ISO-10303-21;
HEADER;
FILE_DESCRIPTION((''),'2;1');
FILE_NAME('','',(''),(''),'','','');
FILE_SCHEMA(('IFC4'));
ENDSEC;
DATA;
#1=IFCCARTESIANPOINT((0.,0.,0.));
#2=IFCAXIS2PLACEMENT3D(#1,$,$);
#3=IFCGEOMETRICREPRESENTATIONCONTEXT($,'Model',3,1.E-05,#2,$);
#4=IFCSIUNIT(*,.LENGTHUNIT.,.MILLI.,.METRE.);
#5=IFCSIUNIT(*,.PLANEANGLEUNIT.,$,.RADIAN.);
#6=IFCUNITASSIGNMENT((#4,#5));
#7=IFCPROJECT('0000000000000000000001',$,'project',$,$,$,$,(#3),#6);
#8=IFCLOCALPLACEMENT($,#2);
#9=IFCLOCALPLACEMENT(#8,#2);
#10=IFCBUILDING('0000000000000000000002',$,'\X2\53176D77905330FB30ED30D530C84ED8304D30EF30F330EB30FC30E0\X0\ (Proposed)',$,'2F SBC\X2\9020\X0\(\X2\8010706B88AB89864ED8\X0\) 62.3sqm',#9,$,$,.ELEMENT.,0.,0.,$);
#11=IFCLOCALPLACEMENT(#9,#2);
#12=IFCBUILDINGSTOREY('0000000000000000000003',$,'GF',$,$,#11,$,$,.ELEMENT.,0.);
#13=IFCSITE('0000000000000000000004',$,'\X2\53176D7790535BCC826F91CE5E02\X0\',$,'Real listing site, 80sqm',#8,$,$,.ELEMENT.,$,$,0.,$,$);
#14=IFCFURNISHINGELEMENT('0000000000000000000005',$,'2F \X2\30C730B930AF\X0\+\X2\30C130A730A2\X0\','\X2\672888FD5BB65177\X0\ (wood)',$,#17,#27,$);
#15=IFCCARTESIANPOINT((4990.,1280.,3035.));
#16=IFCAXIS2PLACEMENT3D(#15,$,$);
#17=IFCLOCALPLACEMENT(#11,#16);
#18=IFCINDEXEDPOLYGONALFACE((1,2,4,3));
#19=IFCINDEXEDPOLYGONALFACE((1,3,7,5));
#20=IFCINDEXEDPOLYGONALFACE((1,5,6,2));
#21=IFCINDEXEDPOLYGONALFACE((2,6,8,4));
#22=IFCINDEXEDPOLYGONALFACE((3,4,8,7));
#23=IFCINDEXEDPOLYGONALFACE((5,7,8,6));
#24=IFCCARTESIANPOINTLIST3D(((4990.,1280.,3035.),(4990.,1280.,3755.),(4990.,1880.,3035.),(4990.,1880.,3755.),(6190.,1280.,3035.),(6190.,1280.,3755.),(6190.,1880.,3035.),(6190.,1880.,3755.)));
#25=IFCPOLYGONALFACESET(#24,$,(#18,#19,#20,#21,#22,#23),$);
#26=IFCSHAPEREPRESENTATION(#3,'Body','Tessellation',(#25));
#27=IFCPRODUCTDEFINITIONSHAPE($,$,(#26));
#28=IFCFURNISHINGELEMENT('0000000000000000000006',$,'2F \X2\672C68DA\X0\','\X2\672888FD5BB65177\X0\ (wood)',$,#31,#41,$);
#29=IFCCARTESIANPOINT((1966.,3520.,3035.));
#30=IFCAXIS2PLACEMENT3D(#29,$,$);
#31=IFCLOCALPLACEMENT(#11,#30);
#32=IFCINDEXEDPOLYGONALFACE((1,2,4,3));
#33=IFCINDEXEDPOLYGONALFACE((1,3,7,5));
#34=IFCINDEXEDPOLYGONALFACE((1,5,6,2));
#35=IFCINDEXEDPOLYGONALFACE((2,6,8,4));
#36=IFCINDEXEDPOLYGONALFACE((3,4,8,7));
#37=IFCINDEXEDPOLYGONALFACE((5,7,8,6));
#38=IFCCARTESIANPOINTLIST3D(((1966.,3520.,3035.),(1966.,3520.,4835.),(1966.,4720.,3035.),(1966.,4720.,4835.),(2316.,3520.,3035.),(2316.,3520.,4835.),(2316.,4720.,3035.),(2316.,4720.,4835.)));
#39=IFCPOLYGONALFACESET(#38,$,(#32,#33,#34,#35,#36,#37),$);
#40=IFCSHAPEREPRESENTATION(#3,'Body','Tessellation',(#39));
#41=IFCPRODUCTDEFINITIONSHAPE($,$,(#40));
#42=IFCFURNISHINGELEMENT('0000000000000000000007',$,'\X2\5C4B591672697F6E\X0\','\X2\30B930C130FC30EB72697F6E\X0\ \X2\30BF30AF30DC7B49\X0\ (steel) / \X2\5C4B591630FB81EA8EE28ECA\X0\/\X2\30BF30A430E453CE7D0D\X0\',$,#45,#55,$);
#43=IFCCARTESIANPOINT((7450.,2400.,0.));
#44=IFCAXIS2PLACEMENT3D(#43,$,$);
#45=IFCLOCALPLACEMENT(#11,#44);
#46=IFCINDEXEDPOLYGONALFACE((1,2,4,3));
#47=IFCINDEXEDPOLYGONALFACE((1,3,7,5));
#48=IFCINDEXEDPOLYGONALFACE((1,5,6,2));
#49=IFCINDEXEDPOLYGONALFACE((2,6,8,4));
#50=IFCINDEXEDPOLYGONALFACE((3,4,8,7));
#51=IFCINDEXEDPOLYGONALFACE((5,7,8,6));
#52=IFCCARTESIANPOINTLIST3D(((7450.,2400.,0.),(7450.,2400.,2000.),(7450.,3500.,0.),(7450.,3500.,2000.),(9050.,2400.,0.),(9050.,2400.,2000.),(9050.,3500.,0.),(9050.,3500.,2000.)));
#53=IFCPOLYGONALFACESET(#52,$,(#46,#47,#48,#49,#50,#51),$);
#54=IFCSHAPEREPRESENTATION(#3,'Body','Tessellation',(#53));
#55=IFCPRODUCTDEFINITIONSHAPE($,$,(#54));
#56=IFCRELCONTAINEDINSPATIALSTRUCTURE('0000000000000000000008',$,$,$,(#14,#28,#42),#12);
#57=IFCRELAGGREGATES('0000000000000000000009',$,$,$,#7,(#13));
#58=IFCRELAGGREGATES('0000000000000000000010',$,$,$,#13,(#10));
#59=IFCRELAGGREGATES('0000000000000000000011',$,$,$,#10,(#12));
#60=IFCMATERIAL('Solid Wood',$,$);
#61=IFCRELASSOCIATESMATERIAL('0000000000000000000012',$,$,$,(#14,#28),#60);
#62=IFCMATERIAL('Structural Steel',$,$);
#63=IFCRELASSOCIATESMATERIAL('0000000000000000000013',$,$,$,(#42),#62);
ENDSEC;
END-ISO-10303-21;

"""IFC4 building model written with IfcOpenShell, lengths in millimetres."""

from ifc_helpers import new_model, si_unit, frame, frame_2d, origin, place, context, project, spatial, rectangle, extrude, material, element, save


model = new_model("IFC4")

# Units and contexts
model_context = context("Model", 3, precision=1e-05, world=origin())
ifc_project = project(units=[si_unit("LENGTHUNIT", "METRE", prefix="MILLI"), si_unit("PLANEANGLEUNIT", "RADIAN")], contexts=[model_context])

# Site, building, storey
site_placement = place(None, origin())
site = spatial("IfcSite", under=ifc_project, at=site_placement, Name="北海道富良野市", ObjectType="Real listing site, 80sqm", CompositionType="ELEMENT", RefElevation=0.0)
building_placement = place(site_placement, origin())
building = spatial("IfcBuilding", under=site, at=building_placement, Name="北海道・ロフト付きワンルーム (Proposed)", ObjectType="2F SBC造(耐火被覆付) 62.3sqm", CompositionType="ELEMENT", ElevationOfRefHeight=0.0, ElevationOfTerrain=0.0)
storey_placement = place(building_placement, origin())
storey = spatial("IfcBuildingStorey", under=building, at=storey_placement, Name="GF", CompositionType="ELEMENT", Elevation=0.0)

# Shared definitions
ifc_material_1 = material(Name="Solid Wood")

# Shared definitions
ifc_material_2 = material(Name="Structural Steel")

# Furnishing elements
furnishing_1_placement = place(storey_placement, frame((4990.0, 1280.0, 3035.0)))
element("IfcFurnishingElement", 1, at=furnishing_1_placement, inside=storey, material=ifc_material_1, Name="2F デスク+チェア", Description="木製家具 (wood)", context=model_context, shape_type="SweptSolid", body=[
    extrude(rectangle(XDim=1200.0, YDim=600.0, at=frame_2d((600.0, 300.0))), frame((4990.0, 1280.0, 3035.0)), (0.0, 0.0, 1.0), 720.0),
])
furnishing_2_placement = place(storey_placement, frame((1966.0, 3520.0, 3035.0)))
element("IfcFurnishingElement", 2, at=furnishing_2_placement, inside=storey, material=ifc_material_1, Name="2F 本棚", Description="木製家具 (wood)", context=model_context, shape_type="SweptSolid", body=[
    extrude(rectangle(XDim=350.0, YDim=1200.0, at=frame_2d((175.0, 600.0))), frame((1966.0, 3520.0, 3035.0)), (0.0, 0.0, 1.0), 1800.0),
])
furnishing_3_placement = place(storey_placement, frame((7450.0, 2400.0, 0.0)))
element("IfcFurnishingElement", 3, at=furnishing_3_placement, inside=storey, material=ifc_material_2, Name="屋外物置", Description="スチール物置 タクボ等 (steel) / 屋外・自転車/タイヤ収納", context=model_context, shape_type="SweptSolid", body=[
    extrude(rectangle(XDim=1600.0, YDim=1100.0, at=frame_2d((800.0, 550.0))), frame((7450.0, 2400.0, 0.0)), (0.0, 0.0, 1.0), 2000.0),
])

save(model, "model.ifc")
